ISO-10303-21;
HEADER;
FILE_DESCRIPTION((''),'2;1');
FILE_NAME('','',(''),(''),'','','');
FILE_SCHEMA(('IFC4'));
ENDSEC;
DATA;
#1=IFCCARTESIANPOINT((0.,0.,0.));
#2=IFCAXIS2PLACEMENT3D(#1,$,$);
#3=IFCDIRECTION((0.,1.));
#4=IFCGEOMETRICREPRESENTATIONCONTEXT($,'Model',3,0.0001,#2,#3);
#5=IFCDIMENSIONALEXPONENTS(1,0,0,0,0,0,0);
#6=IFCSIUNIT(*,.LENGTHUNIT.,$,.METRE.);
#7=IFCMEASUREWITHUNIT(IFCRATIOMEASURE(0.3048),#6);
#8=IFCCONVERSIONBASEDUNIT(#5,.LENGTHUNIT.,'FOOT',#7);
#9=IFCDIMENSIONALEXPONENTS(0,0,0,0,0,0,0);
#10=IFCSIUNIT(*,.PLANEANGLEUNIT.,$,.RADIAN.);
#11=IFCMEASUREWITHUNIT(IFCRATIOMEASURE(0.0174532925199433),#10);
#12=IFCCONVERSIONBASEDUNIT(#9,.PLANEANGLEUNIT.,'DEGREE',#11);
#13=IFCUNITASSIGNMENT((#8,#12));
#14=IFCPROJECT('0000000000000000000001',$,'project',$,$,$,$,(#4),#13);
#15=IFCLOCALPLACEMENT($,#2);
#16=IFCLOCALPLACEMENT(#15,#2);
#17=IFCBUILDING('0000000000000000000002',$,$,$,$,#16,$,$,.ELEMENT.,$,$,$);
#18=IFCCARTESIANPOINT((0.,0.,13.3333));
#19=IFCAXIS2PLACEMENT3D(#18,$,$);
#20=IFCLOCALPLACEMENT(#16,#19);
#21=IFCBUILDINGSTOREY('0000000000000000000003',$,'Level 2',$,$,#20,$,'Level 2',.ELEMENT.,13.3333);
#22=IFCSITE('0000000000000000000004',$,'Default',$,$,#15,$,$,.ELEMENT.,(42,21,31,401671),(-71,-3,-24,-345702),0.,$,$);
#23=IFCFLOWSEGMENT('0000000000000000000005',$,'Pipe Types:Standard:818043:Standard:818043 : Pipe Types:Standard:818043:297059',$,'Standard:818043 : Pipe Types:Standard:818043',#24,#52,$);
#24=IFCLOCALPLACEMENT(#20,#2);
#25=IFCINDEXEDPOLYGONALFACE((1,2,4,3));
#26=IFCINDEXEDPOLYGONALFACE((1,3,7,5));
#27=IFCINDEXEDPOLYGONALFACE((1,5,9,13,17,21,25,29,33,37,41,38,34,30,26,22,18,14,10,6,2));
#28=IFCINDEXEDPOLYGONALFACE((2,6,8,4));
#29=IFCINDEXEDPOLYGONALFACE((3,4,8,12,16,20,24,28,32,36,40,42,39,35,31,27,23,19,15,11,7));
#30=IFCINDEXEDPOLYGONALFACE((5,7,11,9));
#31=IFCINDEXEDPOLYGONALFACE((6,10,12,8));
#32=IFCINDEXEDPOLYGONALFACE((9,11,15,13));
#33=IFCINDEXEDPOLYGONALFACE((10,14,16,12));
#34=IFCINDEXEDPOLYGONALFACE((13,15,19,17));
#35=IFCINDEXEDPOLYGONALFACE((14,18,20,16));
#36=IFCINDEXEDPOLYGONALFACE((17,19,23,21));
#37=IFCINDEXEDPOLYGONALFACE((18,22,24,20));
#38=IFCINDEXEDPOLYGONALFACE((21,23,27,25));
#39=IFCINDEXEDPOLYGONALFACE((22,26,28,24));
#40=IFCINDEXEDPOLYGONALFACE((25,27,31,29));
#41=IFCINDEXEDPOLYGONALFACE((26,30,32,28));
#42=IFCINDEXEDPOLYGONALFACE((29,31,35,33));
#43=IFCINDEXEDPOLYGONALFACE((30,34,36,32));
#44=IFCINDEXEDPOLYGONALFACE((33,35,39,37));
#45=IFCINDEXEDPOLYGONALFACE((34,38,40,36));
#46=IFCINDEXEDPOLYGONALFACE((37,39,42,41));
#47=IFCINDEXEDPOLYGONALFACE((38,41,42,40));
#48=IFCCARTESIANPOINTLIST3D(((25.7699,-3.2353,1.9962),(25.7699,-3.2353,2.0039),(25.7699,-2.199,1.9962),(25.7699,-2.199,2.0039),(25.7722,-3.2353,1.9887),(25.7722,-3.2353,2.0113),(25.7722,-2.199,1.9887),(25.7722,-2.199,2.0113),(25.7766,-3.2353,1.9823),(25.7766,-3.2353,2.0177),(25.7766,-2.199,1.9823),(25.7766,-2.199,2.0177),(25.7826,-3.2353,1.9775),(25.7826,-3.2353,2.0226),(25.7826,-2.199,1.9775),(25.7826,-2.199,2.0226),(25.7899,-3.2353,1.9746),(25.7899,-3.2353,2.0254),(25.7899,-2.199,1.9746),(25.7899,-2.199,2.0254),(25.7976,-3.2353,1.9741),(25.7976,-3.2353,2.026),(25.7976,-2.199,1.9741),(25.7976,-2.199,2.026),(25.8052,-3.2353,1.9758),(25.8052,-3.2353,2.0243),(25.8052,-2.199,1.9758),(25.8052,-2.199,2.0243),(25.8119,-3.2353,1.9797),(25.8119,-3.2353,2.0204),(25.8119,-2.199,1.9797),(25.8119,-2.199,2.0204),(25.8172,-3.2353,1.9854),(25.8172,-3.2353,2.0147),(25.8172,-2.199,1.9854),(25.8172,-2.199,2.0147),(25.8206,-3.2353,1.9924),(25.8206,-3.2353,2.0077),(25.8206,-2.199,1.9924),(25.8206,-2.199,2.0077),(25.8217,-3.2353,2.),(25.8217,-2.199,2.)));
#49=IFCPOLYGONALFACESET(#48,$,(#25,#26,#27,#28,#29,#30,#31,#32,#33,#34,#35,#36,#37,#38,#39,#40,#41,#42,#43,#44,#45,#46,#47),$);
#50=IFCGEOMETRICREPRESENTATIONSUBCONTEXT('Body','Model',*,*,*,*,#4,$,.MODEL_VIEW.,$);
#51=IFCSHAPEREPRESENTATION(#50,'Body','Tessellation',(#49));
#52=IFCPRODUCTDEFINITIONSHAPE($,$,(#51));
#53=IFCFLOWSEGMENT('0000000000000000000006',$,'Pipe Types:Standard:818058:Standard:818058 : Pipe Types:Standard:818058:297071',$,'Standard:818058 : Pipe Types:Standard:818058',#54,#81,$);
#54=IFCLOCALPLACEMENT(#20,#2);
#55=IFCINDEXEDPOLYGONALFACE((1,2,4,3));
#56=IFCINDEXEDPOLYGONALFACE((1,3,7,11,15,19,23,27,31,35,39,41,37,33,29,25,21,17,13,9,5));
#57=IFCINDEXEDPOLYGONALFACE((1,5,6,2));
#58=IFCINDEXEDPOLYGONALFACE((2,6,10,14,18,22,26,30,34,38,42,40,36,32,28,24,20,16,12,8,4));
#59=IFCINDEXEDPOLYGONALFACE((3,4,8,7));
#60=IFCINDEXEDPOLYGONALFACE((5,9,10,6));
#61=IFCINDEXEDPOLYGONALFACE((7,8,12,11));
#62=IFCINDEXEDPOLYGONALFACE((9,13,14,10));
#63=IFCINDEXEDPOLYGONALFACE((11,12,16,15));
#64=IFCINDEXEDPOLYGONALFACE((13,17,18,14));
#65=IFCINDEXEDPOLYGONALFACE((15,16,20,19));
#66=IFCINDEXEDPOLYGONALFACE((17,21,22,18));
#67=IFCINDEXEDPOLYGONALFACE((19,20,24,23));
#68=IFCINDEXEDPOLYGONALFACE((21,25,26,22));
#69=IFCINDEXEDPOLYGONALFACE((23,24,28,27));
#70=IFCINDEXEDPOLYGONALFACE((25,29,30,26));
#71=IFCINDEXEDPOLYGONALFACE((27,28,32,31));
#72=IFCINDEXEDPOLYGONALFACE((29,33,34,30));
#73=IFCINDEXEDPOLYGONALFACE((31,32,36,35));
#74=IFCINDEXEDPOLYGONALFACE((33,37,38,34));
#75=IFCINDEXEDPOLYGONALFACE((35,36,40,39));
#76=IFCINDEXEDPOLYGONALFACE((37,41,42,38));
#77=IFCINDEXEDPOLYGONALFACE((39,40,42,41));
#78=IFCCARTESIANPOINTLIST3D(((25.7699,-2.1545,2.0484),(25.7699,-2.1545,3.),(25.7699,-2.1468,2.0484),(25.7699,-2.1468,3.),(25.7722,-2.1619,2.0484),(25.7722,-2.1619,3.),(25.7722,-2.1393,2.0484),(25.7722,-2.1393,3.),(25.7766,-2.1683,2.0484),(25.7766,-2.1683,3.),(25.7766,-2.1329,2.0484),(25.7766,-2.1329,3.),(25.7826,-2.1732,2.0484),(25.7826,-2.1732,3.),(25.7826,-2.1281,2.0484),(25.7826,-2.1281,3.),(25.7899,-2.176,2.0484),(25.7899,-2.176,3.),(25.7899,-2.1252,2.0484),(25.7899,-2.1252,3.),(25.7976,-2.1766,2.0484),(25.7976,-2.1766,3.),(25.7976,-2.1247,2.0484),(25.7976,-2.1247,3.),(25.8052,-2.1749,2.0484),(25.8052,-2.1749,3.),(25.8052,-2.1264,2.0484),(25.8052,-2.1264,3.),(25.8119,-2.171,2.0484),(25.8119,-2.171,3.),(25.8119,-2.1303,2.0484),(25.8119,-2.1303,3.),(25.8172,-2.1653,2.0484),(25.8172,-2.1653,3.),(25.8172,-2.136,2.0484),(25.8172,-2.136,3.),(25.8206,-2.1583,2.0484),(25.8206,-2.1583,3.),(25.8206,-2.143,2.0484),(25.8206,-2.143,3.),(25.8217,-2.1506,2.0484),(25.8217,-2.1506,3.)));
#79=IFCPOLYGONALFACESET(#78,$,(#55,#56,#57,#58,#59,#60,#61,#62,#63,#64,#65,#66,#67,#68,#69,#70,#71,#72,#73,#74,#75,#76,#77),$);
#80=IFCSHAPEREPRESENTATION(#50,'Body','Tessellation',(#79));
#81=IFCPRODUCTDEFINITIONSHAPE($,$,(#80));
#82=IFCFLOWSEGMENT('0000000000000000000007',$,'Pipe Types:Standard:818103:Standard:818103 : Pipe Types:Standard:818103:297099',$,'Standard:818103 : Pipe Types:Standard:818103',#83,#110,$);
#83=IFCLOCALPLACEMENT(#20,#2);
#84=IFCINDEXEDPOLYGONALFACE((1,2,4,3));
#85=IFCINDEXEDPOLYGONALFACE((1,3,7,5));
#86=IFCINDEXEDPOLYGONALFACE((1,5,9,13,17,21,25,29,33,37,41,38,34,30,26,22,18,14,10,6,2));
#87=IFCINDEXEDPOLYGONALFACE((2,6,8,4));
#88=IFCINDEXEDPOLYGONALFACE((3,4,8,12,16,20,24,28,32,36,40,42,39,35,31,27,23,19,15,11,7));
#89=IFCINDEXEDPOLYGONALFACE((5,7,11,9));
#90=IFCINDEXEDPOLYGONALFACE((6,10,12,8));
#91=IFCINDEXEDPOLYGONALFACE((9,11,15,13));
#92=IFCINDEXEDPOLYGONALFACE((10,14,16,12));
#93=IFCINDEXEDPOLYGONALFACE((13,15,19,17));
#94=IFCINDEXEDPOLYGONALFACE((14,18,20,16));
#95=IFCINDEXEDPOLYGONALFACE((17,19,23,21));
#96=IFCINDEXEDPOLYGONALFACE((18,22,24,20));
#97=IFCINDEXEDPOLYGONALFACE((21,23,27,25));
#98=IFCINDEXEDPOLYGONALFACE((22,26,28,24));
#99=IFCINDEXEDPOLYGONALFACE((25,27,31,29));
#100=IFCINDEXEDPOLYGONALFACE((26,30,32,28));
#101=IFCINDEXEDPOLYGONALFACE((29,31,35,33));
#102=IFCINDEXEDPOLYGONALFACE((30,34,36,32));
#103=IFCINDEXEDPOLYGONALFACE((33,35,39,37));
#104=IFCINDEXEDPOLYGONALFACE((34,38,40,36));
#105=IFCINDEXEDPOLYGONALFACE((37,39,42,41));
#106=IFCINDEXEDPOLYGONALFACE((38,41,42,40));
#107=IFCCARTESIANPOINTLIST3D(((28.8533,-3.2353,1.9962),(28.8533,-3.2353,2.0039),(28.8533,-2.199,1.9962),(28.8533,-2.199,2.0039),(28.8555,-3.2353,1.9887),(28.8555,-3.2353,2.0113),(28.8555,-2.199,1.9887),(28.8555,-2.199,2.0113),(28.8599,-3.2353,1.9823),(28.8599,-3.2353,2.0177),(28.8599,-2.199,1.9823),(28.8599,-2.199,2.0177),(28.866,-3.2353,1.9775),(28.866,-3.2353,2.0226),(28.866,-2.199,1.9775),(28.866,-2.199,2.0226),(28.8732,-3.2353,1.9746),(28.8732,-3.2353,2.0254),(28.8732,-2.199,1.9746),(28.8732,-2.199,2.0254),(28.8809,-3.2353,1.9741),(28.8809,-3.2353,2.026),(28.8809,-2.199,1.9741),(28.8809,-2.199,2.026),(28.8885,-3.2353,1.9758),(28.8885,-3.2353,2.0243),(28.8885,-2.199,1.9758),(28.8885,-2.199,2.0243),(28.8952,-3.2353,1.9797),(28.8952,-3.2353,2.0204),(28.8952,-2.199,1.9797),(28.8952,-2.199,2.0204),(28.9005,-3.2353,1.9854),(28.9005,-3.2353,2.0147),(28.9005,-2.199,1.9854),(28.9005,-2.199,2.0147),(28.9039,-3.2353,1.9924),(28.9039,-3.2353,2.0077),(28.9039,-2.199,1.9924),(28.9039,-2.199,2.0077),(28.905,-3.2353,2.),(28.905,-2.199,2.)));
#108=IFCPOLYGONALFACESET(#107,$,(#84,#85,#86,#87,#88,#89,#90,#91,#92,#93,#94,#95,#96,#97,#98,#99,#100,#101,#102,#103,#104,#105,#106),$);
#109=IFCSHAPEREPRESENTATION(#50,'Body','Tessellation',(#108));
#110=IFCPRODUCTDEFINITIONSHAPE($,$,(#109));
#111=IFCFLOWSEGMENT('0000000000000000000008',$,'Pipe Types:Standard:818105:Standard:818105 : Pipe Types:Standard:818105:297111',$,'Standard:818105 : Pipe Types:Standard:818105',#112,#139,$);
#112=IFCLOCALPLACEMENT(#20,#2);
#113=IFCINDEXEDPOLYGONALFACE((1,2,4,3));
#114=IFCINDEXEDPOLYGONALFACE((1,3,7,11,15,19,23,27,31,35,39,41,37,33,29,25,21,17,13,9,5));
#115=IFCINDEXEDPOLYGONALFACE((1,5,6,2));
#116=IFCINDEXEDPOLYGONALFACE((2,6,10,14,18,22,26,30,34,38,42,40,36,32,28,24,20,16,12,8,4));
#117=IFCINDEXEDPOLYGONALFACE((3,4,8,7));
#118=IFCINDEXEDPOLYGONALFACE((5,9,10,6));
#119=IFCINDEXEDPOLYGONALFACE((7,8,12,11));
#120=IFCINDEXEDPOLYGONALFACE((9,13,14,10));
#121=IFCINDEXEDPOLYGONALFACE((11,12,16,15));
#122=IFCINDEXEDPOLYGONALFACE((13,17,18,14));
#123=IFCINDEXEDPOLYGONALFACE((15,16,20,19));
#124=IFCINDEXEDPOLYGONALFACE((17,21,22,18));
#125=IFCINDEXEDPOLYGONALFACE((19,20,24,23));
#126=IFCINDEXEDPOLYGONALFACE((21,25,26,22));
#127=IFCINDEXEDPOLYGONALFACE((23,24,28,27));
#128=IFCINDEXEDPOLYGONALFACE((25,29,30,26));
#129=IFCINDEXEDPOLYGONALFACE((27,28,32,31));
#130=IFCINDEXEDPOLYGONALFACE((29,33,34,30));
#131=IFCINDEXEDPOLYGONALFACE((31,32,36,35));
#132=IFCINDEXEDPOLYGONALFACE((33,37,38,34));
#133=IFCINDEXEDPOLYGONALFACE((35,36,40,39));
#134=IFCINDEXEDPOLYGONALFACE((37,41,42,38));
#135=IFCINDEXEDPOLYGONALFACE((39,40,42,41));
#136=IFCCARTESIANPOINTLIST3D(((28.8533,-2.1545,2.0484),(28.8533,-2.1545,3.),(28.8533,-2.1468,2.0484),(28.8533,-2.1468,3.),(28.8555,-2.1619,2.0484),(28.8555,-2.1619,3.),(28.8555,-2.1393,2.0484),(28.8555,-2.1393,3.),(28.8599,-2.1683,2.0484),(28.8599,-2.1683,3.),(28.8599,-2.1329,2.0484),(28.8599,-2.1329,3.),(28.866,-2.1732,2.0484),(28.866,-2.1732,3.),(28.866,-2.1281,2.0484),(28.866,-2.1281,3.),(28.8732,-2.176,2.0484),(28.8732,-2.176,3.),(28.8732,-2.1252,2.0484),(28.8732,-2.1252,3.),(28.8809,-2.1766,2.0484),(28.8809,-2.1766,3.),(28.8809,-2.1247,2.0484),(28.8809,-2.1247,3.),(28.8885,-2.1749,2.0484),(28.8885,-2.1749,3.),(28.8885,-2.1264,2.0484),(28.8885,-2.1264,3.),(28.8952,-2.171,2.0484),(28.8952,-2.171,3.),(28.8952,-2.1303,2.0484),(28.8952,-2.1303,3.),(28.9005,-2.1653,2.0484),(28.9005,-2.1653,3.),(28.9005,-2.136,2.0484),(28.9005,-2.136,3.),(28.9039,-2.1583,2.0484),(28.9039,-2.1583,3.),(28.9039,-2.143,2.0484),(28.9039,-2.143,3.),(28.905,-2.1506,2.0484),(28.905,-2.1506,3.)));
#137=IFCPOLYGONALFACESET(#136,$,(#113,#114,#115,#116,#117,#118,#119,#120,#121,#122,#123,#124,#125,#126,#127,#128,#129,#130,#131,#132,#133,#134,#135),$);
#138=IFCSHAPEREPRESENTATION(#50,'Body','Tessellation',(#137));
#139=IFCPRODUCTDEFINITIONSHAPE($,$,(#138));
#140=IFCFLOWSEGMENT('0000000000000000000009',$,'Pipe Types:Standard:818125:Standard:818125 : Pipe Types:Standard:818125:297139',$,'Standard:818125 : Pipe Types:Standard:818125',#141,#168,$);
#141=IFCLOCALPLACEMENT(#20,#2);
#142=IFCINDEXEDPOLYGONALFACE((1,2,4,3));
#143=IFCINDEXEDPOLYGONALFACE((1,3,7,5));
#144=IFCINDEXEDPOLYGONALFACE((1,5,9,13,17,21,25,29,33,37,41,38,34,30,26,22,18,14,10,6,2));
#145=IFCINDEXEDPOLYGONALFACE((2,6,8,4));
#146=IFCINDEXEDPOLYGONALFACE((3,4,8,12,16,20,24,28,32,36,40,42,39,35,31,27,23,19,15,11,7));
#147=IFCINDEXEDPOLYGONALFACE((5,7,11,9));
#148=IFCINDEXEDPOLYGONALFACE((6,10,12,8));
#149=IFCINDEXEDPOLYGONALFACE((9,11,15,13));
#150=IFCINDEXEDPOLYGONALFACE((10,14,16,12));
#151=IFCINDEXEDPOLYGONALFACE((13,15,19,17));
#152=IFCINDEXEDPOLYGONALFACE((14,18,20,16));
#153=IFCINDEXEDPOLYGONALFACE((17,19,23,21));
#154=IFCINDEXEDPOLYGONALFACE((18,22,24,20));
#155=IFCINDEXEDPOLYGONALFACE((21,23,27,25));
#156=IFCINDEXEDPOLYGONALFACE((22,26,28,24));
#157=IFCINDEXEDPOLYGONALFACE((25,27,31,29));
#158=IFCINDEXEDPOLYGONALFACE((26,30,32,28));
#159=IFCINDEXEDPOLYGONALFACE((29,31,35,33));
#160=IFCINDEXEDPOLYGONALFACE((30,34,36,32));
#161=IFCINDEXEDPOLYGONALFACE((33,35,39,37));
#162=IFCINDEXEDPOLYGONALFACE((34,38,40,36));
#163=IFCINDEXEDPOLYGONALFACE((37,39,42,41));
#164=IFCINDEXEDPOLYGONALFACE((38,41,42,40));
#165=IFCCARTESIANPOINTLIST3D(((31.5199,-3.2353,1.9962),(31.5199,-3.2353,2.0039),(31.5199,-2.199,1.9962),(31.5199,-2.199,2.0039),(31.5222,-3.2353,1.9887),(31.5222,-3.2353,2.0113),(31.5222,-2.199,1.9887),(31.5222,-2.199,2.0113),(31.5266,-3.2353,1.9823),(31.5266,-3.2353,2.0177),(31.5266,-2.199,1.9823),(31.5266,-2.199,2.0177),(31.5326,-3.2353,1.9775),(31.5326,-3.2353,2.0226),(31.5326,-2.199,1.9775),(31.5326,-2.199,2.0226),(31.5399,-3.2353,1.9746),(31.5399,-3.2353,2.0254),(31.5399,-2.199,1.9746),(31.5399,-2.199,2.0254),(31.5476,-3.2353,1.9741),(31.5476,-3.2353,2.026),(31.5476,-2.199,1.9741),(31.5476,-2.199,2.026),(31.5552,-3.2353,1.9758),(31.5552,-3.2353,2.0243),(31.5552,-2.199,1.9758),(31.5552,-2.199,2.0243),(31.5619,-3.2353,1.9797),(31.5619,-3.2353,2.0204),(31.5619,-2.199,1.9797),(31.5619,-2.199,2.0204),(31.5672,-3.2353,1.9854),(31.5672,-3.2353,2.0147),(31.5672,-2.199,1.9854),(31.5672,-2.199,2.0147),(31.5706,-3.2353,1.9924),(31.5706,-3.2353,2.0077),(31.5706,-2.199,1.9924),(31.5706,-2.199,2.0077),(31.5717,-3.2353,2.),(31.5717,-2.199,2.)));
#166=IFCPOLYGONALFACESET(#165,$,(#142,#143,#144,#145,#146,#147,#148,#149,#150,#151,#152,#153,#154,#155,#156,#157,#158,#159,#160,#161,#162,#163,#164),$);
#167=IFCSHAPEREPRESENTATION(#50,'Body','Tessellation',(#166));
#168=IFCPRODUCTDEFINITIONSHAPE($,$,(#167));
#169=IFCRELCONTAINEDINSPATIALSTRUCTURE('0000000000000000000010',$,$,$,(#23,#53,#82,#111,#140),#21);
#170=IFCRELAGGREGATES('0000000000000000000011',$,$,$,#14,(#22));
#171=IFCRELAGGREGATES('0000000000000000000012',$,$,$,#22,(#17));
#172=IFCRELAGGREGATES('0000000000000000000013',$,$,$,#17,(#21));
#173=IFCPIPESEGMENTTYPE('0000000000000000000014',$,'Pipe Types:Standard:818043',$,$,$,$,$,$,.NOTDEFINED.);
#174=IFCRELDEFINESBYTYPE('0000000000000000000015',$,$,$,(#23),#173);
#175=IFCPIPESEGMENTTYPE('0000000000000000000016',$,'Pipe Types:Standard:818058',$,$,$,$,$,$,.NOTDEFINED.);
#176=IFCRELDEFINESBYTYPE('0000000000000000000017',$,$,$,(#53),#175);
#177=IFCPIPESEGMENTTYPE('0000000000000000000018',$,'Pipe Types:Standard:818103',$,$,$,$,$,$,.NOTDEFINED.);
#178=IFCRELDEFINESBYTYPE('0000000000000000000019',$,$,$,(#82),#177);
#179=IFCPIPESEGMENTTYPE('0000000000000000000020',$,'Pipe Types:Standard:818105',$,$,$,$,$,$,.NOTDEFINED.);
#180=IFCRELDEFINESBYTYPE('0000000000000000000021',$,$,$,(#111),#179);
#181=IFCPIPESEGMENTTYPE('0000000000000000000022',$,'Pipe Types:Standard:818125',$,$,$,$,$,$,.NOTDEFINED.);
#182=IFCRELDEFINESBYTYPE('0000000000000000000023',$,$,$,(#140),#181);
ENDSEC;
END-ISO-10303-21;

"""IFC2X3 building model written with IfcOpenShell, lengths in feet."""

from ifc_helpers import new_model, entity, si_unit, converted_unit, direction, frame, origin, origin_2d_with_axis, place, context, subcontext, project, spatial, circle, extrude, source, transform, mapped, type_object, type_shapes, element, save


model = new_model("IFC2X3")

# Units and contexts
model_context = context("Model", 3, precision=0.0001, world=origin(), true_north=direction((0.0, 1.0)))
body_context = subcontext(model_context, "Body", "Model", "MODEL_VIEW")
ifc_project = project(units=[converted_unit("LENGTHUNIT", "FOOT", entity("IfcRatioMeasure", 0.3048), si_unit("LENGTHUNIT", "METRE"), dimensions=[1, 0, 0, 0, 0, 0, 0]), converted_unit("PLANEANGLEUNIT", "DEGREE", entity("IfcRatioMeasure", 0.0174532925199433), si_unit("PLANEANGLEUNIT", "RADIAN"), dimensions=[0, 0, 0, 0, 0, 0, 0])], contexts=[model_context])

# Site, building, storey
site_placement = place(None, origin())
site = spatial("IfcSite", under=ifc_project, at=site_placement, Name="Default", CompositionType="ELEMENT", RefLatitude=(42, 21, 31, 401671), RefLongitude=(-71, -3, -24, -345702), RefElevation=0.0)
building_placement = place(site_placement, origin())
building = spatial("IfcBuilding", under=site, at=building_placement, CompositionType="ELEMENT")
storey_placement = place(building_placement, frame((0.0, 0.0, 13.3333)))
storey = spatial("IfcBuildingStorey", under=building, at=storey_placement, Name="Level 2", LongName="Level 2", CompositionType="ELEMENT", Elevation=13.3333)

# Flow segments
pipe_segment_type_1 = type_object("IfcPipeSegmentType", Name="Pipe Types:Standard:818043", PredefinedType="NOTDEFINED")
shared_shape_1 = source(origin(), body_context, "Body", "SweptSolid", [
    extrude(circle(Radius=0.026, at=origin_2d_with_axis()), frame((25.7957, -3.2353, 15.3333), z_axis=(0.0, 1.0, 0.0), x_axis=(1.0, 0.0, 0.0)), (0.0, 0.0, 1.0), 1.0363),
])
type_shapes(pipe_segment_type_1, [shared_shape_1])
flow_segment_1_placement = place(building_placement, origin())
element("IfcFlowSegment", 1, at=flow_segment_1_placement, inside=storey, type_object=pipe_segment_type_1, Name="Pipe Types:Standard:818043:Standard:818043 : Pipe Types:Standard:818043:297059", ObjectType="Standard:818043 : Pipe Types:Standard:818043", context=body_context, shape_type="MappedRepresentation", body=[
    mapped(shared_shape_1, transform((0.0, 0.0, 0.0), scale=1.0)),
])
pipe_segment_type_2 = type_object("IfcPipeSegmentType", Name="Pipe Types:Standard:818058", PredefinedType="NOTDEFINED")
shared_shape_2 = source(origin(), body_context, "Body", "SweptSolid", [
    extrude(circle(Radius=0.026, at=origin_2d_with_axis()), frame((25.7957, -2.1506, 15.3817)), (0.0, 0.0, 1.0), 0.9517),
])
type_shapes(pipe_segment_type_2, [shared_shape_2])
flow_segment_2_placement = place(building_placement, origin())
element("IfcFlowSegment", 2, at=flow_segment_2_placement, inside=storey, type_object=pipe_segment_type_2, Name="Pipe Types:Standard:818058:Standard:818058 : Pipe Types:Standard:818058:297071", ObjectType="Standard:818058 : Pipe Types:Standard:818058", context=body_context, shape_type="MappedRepresentation", body=[
    mapped(shared_shape_2, transform((0.0, 0.0, 0.0), scale=1.0)),
])
pipe_segment_type_3 = type_object("IfcPipeSegmentType", Name="Pipe Types:Standard:818103", PredefinedType="NOTDEFINED")
shared_shape_3 = source(origin(), body_context, "Body", "SweptSolid", [
    extrude(circle(Radius=0.026, at=origin_2d_with_axis()), frame((28.879, -3.2353, 15.3333), z_axis=(0.0, 1.0, 0.0), x_axis=(1.0, 0.0, 0.0)), (0.0, 0.0, 1.0), 1.0363),
])
type_shapes(pipe_segment_type_3, [shared_shape_3])
flow_segment_3_placement = place(building_placement, origin())
element("IfcFlowSegment", 3, at=flow_segment_3_placement, inside=storey, type_object=pipe_segment_type_3, Name="Pipe Types:Standard:818103:Standard:818103 : Pipe Types:Standard:818103:297099", ObjectType="Standard:818103 : Pipe Types:Standard:818103", context=body_context, shape_type="MappedRepresentation", body=[
    mapped(shared_shape_3, transform((0.0, 0.0, 0.0), scale=1.0)),
])
pipe_segment_type_4 = type_object("IfcPipeSegmentType", Name="Pipe Types:Standard:818105", PredefinedType="NOTDEFINED")
shared_shape_4 = source(origin(), body_context, "Body", "SweptSolid", [
    extrude(circle(Radius=0.026, at=origin_2d_with_axis()), frame((28.879, -2.1506, 15.3817)), (0.0, 0.0, 1.0), 0.9517),
])
type_shapes(pipe_segment_type_4, [shared_shape_4])
flow_segment_4_placement = place(building_placement, origin())
element("IfcFlowSegment", 4, at=flow_segment_4_placement, inside=storey, type_object=pipe_segment_type_4, Name="Pipe Types:Standard:818105:Standard:818105 : Pipe Types:Standard:818105:297111", ObjectType="Standard:818105 : Pipe Types:Standard:818105", context=body_context, shape_type="MappedRepresentation", body=[
    mapped(shared_shape_4, transform((0.0, 0.0, 0.0), scale=1.0)),
])
pipe_segment_type_5 = type_object("IfcPipeSegmentType", Name="Pipe Types:Standard:818125", PredefinedType="NOTDEFINED")
shared_shape_5 = source(origin(), body_context, "Body", "SweptSolid", [
    extrude(circle(Radius=0.026, at=origin_2d_with_axis()), frame((31.5457, -3.2353, 15.3333), z_axis=(0.0, 1.0, 0.0), x_axis=(1.0, 0.0, 0.0)), (0.0, 0.0, 1.0), 1.0363),
])
type_shapes(pipe_segment_type_5, [shared_shape_5])
flow_segment_5_placement = place(building_placement, origin())
element("IfcFlowSegment", 5, at=flow_segment_5_placement, inside=storey, type_object=pipe_segment_type_5, Name="Pipe Types:Standard:818125:Standard:818125 : Pipe Types:Standard:818125:297139", ObjectType="Standard:818125 : Pipe Types:Standard:818125", context=body_context, shape_type="MappedRepresentation", body=[
    mapped(shared_shape_5, transform((0.0, 0.0, 0.0), scale=1.0)),
])

save(model, "model.ifc")
